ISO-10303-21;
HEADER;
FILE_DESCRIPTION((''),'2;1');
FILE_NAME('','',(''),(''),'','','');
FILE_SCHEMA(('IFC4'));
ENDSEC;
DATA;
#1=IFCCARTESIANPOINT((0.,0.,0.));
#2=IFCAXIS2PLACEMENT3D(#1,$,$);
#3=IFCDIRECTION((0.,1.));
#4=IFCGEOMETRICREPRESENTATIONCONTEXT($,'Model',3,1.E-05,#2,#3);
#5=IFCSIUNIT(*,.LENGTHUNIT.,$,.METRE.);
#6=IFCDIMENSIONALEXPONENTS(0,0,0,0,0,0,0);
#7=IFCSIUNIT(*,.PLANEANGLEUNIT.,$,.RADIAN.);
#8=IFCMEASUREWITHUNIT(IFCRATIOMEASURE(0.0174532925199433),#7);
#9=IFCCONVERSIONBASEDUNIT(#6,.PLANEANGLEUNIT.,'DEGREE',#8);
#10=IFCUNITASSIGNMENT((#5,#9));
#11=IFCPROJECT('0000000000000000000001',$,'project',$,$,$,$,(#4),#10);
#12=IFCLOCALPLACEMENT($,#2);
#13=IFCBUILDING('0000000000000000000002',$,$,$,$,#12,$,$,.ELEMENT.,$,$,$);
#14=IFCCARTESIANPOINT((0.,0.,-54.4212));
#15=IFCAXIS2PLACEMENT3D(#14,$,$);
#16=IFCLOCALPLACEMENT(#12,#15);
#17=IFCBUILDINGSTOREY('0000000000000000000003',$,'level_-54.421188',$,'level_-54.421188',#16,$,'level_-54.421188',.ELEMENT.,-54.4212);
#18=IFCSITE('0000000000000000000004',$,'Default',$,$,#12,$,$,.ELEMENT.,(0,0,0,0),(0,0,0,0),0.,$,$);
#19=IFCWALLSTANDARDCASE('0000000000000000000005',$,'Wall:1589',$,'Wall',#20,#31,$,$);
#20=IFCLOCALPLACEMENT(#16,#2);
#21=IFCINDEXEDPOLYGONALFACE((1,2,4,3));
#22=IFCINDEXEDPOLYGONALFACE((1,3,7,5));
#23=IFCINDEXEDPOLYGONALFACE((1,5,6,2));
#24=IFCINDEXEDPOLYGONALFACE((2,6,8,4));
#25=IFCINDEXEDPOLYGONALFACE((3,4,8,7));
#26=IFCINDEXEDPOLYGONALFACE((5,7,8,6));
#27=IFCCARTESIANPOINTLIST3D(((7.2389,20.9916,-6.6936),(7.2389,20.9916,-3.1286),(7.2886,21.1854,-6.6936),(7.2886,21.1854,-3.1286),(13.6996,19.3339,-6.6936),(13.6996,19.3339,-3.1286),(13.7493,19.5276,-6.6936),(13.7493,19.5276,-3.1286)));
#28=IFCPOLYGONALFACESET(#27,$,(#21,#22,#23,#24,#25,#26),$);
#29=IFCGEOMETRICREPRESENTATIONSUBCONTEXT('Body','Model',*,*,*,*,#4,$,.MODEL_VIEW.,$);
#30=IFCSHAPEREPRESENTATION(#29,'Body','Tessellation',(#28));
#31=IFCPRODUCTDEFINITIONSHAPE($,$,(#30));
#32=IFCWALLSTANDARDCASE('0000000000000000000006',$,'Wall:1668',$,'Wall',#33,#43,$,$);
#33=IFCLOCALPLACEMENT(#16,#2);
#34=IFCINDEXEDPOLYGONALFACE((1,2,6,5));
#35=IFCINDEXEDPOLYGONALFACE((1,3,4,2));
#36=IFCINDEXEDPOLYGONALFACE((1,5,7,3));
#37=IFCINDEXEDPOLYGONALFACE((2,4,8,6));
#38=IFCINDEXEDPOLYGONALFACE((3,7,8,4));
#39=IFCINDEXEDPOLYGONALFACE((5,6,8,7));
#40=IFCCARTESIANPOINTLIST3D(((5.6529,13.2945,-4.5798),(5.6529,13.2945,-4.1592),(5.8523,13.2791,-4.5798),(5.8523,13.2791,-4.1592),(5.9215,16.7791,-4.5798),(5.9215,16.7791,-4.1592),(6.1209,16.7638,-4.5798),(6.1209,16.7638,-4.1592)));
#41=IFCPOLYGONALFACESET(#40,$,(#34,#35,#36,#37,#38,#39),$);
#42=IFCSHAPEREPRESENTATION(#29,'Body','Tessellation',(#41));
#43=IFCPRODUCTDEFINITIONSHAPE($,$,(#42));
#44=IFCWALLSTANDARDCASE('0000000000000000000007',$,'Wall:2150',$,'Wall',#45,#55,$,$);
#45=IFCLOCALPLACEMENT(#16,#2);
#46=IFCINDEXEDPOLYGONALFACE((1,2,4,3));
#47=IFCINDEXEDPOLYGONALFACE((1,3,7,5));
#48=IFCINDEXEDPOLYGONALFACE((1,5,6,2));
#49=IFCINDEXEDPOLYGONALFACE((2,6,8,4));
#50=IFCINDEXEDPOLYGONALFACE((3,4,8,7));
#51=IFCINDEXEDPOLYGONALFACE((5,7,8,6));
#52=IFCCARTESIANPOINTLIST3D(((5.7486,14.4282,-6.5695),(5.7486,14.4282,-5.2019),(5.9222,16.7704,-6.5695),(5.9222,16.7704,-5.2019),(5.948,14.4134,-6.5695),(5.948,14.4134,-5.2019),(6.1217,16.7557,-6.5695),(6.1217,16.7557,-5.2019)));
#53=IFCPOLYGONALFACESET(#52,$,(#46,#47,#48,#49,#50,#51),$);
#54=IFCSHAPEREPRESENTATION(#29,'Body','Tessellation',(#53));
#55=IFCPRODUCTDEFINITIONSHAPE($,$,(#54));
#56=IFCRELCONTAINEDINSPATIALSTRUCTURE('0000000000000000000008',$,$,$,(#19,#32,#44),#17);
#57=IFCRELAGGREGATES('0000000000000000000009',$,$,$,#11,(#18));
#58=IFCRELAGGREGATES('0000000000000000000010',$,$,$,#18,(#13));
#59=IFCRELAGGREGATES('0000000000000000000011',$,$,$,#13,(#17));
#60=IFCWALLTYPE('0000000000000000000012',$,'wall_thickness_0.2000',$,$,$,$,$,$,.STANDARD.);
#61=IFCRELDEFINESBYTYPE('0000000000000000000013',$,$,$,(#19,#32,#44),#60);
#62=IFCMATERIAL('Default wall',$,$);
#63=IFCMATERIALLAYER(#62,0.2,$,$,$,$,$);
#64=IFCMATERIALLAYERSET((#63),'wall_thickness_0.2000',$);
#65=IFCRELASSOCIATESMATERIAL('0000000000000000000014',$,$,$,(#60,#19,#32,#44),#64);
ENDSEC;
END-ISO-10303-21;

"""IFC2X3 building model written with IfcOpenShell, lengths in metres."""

from ifc_helpers import new_model, entity, si_unit, converted_unit, direction, frame, origin, place, context, subcontext, project, spatial, polyline, outline, extrude, material, layer, layer_set, layer_usage, type_object, element, save


model = new_model("IFC2X3")

# Units and contexts
model_context = context("Model", 3, precision=1e-05, world=origin(), true_north=direction((0.0, 1.0)))
body_context = subcontext(model_context, "Body", "Model", "MODEL_VIEW")
ifc_project = project(units=[si_unit("LENGTHUNIT", "METRE"), converted_unit("PLANEANGLEUNIT", "DEGREE", entity("IfcRatioMeasure", 0.0174532925199433), si_unit("PLANEANGLEUNIT", "RADIAN"), dimensions=[0, 0, 0, 0, 0, 0, 0])], contexts=[model_context])

# Site, building, storey
placement_1 = place(None, origin())
site = spatial("IfcSite", under=ifc_project, at=placement_1, Name="Default", CompositionType="ELEMENT", RefLatitude=(0, 0, 0, 0), RefLongitude=(0, 0, 0, 0), RefElevation=0.0)
building = spatial("IfcBuilding", under=site, at=placement_1, CompositionType="ELEMENT")
storey_placement = place(placement_1, frame((0.0, 0.0, -54.4212)))
storey = spatial("IfcBuildingStorey", under=building, at=storey_placement, Name="level_-54.421188", ObjectType="level_-54.421188", LongName="level_-54.421188", CompositionType="ELEMENT", Elevation=-54.4212)

# Shared definitions
ifc_material_1 = material(Name="Default wall")
ifc_layer = layer(ifc_material_1, 0.2)
ifc_layer_set = layer_set([ifc_layer], Name="wall_thickness_0.2000")
ifc_layer_usage = layer_usage(ifc_layer_set, "AXIS2", "POSITIVE", -0.1)
wall_type = type_object("IfcWallType", Name="wall_thickness_0.2000", PredefinedType="STANDARD", material=ifc_layer_set)

# Walls
placement_2 = place(placement_1, frame((0.0, 0.0, -61.1148)))
wall_1_placement = place(placement_2, frame((7.2637, 21.0885, 0.0), z_axis=(0.0, 0.0, 1.0), x_axis=(0.968621, -0.248542, 0.0)))
element("IfcWallStandardCase", 1, at=wall_1_placement, inside=storey, type_object=wall_type, material=ifc_layer_usage, Name="Wall:1589", ObjectType="Wall", context=body_context, shape_type="SweptSolid", body=[
    extrude(outline(polyline([(6.67, -0.1), (6.67, 0.1), (0.0, 0.1), (0.0, -0.1), (6.67, -0.1)])), origin(), (0.0, 0.0, 1.0), 3.5651),
])
placement_3 = place(placement_1, frame((0.0, 0.0, -59.001)))
wall_2_placement = place(placement_3, frame((6.0212, 16.7714, 0.0), z_axis=(0.0, 0.0, 1.0), x_axis=(-0.076848, -0.997043, 0.0)))
element("IfcWallStandardCase", 2, at=wall_2_placement, inside=storey, type_object=wall_type, material=ifc_layer_usage, Name="Wall:1668", ObjectType="Wall", context=body_context, shape_type="SweptSolid", body=[
    extrude(outline(polyline([(3.495, -0.1), (3.495, 0.1), (0.0, 0.1), (0.0, -0.1), (3.495, -0.1)])), origin(), (0.0, 0.0, 1.0), 0.4206),
])
placement_4 = place(placement_1, frame((0.0, 0.0, -60.9907)))
wall_3_placement = place(placement_4, frame((5.8483, 14.4208, 0.0), z_axis=(0.0, 0.0, 1.0), x_axis=(0.073948, 0.997262, 0.0)))
element("IfcWallStandardCase", 3, at=wall_3_placement, inside=storey, type_object=wall_type, material=ifc_layer_usage, Name="Wall:2150", ObjectType="Wall", context=body_context, shape_type="SweptSolid", body=[
    extrude(outline(polyline([(2.3487, -0.1), (2.3487, 0.1), (0.0, 0.1), (0.0, -0.1), (2.3487, -0.1)])), origin(), (0.0, 0.0, 1.0), 1.3675),
])

save(model, "model.ifc")
